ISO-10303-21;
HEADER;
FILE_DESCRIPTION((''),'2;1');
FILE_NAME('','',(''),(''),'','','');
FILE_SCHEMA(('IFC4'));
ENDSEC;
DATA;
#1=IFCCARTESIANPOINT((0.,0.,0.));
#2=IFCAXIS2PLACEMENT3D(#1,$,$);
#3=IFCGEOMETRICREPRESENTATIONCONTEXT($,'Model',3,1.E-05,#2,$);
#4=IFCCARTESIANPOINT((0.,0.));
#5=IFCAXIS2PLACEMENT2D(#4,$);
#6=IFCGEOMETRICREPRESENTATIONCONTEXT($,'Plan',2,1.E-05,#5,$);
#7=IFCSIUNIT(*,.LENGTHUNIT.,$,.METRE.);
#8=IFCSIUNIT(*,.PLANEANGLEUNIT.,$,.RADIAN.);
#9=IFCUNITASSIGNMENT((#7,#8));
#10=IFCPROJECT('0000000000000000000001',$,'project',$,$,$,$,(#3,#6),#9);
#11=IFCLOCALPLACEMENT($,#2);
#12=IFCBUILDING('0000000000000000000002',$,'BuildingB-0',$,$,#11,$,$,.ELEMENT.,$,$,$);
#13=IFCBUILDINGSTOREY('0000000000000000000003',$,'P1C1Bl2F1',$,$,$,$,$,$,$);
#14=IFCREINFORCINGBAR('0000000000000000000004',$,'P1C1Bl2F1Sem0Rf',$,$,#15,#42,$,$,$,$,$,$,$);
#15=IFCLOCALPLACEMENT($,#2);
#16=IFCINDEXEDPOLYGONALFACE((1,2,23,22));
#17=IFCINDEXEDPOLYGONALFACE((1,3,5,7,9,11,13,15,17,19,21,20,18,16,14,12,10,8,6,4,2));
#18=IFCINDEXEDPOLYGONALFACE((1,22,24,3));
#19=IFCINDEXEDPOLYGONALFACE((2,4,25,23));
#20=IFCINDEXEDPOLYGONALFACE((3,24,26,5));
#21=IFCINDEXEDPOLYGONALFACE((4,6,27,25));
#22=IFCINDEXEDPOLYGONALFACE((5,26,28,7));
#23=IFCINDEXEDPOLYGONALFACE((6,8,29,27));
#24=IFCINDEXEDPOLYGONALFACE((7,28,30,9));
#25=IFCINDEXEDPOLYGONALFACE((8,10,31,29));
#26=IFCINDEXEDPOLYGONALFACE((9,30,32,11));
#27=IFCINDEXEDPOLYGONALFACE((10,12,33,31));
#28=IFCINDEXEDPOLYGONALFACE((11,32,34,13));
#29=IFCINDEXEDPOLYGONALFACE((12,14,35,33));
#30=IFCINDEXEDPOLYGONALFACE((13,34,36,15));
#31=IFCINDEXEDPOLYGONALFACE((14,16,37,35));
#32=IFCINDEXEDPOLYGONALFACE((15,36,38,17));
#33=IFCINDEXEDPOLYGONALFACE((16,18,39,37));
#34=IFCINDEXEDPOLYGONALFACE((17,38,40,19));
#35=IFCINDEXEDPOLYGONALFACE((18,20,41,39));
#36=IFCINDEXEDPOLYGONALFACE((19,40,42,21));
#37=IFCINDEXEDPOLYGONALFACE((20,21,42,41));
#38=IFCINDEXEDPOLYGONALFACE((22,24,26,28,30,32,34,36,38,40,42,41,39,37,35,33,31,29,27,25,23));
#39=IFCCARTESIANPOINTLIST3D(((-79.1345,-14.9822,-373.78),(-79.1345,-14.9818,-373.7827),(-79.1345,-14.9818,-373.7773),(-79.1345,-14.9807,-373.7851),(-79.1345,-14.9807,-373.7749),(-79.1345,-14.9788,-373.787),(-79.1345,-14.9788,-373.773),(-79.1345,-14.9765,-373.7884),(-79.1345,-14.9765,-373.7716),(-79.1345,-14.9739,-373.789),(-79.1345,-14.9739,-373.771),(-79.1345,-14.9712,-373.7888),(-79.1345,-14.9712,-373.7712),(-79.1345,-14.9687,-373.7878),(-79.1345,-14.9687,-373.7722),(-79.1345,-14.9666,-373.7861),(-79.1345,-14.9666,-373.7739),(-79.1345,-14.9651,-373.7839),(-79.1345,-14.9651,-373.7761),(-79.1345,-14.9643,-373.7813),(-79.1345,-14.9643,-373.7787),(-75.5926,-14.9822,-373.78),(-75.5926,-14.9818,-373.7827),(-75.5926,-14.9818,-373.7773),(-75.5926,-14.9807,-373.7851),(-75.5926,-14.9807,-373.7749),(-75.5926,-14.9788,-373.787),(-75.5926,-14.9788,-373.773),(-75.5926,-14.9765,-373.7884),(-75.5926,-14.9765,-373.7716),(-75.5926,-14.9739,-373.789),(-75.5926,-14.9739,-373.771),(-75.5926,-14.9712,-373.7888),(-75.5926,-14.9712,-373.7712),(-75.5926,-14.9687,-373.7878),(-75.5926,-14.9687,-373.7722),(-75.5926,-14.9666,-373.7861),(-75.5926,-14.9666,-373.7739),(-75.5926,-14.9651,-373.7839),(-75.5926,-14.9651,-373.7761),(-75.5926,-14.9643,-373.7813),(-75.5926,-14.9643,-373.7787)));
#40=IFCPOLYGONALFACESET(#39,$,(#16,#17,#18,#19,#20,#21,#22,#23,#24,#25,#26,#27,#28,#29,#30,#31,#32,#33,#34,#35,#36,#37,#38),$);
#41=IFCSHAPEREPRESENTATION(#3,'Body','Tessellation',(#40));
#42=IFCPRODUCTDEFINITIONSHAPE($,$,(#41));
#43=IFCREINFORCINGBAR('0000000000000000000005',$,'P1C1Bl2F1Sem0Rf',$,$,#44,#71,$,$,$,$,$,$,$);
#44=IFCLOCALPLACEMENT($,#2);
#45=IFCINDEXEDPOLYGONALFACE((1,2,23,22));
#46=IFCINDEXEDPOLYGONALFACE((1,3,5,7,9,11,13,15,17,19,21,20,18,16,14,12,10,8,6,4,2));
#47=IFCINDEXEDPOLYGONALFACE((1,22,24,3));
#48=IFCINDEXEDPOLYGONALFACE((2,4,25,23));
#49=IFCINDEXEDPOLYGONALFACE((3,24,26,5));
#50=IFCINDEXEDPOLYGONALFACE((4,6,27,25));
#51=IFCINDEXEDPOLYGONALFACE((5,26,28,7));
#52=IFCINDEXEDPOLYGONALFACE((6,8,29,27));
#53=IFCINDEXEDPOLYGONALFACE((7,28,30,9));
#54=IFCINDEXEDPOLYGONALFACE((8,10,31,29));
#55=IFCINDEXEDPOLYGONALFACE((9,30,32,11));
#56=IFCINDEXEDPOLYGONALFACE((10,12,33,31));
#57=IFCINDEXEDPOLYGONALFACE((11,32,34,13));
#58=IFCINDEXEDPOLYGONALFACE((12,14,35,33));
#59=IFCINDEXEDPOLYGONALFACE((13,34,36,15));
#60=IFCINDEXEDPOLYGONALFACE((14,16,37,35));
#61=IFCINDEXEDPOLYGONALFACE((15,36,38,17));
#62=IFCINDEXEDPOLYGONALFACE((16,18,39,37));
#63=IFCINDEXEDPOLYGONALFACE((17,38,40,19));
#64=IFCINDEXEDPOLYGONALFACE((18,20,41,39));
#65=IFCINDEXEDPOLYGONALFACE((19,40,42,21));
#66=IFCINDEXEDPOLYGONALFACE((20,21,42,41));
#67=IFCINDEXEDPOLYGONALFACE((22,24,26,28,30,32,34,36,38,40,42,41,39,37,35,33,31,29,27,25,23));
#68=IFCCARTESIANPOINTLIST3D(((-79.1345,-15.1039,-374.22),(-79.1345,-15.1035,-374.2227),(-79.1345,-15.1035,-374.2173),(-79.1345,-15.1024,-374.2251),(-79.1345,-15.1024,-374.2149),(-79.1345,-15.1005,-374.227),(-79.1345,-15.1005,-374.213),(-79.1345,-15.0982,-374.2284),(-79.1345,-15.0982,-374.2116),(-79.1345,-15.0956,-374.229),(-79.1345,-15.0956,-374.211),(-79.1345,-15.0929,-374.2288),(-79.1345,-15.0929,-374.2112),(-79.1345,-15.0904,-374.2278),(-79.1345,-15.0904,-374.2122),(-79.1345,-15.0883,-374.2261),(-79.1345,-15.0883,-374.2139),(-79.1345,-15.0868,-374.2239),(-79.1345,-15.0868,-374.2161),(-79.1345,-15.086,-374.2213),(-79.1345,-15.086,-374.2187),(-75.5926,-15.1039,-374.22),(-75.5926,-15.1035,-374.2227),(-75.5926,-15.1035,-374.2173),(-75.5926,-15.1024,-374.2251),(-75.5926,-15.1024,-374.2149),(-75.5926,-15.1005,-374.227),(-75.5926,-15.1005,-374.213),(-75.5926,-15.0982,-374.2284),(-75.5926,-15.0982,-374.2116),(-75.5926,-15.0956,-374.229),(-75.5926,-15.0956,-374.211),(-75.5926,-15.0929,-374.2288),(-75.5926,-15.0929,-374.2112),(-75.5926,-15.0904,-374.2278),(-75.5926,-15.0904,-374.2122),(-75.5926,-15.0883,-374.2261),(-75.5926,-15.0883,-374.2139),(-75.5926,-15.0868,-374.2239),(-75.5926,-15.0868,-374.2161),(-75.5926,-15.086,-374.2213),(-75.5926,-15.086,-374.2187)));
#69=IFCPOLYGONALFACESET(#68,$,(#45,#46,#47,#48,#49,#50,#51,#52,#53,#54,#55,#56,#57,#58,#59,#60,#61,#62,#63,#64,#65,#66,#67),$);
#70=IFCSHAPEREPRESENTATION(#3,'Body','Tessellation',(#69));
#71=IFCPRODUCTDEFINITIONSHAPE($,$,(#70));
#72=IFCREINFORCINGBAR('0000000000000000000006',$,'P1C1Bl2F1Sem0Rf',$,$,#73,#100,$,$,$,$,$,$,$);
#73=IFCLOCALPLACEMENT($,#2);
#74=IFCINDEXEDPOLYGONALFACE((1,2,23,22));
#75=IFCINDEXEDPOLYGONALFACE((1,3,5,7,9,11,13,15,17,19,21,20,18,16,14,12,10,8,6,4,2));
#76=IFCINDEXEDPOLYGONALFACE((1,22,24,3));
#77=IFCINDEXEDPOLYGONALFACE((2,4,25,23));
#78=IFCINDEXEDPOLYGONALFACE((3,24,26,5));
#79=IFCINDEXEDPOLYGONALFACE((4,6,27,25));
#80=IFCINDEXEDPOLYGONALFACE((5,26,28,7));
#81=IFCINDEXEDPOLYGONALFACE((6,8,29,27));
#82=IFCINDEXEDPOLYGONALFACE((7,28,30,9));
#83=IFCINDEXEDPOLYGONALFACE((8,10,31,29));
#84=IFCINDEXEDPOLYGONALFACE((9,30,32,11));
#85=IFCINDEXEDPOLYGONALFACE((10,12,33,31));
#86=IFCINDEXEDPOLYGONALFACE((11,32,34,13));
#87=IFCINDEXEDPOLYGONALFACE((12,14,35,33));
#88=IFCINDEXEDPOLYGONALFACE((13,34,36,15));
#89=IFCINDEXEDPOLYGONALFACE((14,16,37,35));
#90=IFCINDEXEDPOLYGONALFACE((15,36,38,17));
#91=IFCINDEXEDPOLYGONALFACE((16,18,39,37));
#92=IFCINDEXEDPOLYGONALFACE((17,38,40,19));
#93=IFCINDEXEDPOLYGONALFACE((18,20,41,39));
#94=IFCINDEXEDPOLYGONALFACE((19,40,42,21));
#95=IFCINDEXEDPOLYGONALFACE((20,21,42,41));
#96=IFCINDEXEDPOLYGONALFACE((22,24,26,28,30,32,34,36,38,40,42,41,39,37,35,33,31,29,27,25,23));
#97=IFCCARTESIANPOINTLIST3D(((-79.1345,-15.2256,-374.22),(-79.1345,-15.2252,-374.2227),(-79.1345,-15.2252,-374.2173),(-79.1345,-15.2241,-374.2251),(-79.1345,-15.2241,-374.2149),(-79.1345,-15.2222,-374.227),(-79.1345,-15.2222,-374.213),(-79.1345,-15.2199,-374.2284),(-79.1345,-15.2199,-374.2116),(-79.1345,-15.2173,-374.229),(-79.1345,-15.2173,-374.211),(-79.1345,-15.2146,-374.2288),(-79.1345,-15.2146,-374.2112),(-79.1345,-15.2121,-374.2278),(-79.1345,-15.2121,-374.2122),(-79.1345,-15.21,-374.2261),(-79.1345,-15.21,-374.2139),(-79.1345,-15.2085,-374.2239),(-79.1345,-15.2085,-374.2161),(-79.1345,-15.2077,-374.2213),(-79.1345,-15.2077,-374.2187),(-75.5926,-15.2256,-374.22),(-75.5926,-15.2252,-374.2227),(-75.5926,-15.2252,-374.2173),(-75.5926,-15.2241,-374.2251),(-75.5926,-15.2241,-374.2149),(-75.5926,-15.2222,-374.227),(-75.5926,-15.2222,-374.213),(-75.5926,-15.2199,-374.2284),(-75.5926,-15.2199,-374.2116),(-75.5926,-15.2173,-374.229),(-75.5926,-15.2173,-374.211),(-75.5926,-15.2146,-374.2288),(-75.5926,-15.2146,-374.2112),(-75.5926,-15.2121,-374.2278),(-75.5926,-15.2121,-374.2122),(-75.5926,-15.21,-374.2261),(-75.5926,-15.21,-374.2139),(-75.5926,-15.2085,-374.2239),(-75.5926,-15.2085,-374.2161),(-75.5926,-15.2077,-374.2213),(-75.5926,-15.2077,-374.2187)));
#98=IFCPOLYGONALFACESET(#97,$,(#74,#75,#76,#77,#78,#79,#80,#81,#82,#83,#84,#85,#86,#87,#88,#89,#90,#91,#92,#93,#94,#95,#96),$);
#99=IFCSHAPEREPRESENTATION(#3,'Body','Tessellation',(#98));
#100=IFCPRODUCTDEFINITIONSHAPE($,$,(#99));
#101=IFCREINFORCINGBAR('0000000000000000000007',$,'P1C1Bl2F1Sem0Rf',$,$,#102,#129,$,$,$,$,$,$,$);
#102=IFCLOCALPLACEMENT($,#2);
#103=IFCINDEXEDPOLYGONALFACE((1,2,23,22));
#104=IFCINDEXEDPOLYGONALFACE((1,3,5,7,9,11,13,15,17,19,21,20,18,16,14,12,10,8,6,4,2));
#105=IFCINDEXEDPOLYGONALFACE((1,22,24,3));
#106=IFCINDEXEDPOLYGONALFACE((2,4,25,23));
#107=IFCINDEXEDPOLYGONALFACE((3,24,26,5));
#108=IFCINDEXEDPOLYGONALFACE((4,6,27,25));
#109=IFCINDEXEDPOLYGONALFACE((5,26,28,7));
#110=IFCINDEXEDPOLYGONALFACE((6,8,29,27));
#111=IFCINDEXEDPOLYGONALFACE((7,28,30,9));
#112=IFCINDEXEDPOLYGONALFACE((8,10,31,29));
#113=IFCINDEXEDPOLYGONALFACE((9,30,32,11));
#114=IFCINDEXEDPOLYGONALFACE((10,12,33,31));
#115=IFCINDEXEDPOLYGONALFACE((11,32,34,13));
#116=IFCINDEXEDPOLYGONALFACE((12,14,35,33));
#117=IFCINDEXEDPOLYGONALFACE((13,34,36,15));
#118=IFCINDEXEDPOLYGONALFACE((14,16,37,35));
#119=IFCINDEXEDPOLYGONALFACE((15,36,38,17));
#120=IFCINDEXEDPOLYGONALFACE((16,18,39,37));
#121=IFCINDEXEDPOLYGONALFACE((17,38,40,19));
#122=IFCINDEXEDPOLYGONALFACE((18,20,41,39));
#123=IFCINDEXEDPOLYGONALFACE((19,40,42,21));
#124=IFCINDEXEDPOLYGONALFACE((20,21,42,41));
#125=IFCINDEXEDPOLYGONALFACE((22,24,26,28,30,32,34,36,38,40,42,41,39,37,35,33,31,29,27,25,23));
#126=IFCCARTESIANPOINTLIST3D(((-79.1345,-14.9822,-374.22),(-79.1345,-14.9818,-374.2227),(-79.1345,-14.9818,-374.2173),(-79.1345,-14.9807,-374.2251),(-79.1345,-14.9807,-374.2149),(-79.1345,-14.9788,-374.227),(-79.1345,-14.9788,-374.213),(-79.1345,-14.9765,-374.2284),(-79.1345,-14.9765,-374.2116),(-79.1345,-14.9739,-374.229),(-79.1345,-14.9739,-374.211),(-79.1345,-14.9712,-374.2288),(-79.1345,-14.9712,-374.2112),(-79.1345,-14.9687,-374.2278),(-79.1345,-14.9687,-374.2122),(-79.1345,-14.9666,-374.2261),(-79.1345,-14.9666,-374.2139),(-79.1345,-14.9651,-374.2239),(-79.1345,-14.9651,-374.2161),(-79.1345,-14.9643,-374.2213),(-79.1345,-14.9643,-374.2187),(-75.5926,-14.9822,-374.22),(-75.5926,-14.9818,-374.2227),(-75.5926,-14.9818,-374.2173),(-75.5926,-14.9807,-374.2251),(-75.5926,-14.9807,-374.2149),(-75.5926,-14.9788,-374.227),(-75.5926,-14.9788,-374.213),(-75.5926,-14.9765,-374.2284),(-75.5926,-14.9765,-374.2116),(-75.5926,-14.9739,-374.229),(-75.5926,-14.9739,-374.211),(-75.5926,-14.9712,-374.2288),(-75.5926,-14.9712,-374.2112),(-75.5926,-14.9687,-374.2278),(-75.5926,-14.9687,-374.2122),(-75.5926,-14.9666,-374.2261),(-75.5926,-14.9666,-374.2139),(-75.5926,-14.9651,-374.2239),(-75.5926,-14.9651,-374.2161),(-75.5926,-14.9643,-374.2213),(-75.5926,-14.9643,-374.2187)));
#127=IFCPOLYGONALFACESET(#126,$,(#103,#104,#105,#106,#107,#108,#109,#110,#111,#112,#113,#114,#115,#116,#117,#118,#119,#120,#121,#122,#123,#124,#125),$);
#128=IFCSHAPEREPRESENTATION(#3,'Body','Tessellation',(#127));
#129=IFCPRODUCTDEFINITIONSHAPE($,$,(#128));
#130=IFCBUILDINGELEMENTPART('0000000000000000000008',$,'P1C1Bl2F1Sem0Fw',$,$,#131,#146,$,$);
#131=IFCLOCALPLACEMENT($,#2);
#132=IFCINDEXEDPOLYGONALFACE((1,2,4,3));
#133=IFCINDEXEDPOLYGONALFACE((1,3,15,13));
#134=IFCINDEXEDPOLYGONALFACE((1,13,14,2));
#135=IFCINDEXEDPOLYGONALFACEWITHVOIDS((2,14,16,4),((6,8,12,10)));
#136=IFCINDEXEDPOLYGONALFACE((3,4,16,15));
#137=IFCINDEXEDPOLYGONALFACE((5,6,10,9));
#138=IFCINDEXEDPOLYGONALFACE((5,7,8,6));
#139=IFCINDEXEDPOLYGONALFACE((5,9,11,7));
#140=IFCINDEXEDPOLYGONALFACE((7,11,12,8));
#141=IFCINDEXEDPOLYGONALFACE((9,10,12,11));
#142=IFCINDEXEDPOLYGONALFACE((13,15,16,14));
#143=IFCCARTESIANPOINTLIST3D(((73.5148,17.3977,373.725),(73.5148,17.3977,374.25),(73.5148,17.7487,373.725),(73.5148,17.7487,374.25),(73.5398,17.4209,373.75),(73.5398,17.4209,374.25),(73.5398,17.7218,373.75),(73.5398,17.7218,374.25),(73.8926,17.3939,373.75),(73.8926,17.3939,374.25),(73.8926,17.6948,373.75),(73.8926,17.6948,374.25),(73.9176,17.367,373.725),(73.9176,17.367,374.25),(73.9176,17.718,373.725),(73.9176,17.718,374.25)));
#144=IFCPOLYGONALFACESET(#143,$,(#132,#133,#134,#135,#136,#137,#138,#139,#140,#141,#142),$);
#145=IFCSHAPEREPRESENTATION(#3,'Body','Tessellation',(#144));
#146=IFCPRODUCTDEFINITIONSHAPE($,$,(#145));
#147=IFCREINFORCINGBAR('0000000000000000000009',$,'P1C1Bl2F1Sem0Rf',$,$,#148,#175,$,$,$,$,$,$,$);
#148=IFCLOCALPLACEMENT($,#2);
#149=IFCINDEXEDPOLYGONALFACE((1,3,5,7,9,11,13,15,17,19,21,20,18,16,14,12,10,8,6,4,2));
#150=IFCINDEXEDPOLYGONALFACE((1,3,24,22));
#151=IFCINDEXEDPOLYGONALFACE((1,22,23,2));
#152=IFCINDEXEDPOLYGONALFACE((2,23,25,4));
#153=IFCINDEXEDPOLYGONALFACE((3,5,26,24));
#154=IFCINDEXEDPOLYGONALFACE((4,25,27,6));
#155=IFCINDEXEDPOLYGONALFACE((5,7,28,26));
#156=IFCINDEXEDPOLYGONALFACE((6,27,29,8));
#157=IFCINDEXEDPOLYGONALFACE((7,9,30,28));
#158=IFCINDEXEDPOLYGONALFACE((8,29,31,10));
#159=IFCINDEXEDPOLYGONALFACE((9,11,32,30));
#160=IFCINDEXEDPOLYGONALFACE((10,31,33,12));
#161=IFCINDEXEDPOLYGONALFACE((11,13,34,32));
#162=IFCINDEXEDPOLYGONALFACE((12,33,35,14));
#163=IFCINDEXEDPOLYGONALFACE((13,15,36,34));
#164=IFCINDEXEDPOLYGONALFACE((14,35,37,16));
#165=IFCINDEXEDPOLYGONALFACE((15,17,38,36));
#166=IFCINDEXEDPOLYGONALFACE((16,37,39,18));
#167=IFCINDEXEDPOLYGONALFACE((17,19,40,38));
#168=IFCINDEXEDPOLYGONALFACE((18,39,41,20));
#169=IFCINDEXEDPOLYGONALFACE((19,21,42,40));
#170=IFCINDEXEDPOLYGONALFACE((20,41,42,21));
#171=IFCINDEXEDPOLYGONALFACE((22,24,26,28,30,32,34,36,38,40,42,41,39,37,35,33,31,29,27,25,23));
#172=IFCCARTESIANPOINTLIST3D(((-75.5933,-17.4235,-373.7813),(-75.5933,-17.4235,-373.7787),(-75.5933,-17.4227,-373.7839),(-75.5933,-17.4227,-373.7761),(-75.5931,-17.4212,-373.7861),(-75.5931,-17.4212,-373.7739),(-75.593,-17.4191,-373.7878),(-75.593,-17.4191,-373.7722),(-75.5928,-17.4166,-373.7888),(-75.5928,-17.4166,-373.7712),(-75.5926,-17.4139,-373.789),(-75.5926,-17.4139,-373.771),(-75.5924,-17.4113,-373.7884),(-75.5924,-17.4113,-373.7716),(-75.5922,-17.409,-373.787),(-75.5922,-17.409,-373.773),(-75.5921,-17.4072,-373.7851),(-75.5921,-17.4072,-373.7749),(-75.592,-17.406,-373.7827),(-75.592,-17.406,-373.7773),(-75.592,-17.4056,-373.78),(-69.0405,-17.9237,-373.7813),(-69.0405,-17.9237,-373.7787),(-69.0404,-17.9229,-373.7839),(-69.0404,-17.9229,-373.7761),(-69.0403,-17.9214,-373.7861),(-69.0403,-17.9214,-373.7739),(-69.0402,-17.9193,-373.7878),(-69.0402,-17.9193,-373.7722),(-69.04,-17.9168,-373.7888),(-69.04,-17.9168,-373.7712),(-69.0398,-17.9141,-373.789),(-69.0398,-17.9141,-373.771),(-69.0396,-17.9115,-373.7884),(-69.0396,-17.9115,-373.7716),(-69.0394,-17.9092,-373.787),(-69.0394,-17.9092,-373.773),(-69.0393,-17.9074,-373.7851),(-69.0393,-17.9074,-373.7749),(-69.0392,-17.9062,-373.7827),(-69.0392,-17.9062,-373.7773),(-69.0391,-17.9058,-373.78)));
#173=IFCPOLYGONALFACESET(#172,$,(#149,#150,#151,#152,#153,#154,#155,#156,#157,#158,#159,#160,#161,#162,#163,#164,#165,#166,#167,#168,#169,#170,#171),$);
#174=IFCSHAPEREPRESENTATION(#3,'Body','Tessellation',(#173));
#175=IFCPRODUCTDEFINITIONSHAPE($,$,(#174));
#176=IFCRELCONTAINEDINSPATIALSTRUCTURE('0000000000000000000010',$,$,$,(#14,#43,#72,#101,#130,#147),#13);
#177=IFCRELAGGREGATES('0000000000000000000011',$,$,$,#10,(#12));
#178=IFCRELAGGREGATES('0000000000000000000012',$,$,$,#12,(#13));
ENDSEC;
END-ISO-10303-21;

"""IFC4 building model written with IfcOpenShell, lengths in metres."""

from ifc_helpers import new_model, entity, si_unit, origin, origin_2d, place, context, project, spatial, polyline, outline, extrude, element, save


model = new_model("IFC4")

# Units and contexts
model_context = context("Model", 3, precision=1e-05, world=origin())
plan_context = context("Plan", 2, precision=1e-05, world=origin_2d())
ifc_project = project(units=[si_unit("LENGTHUNIT", "METRE"), si_unit("PLANEANGLEUNIT", "RADIAN")], contexts=[model_context, plan_context])

# Building, storey
building_placement = place(None, origin())
building = spatial("IfcBuilding", under=ifc_project, at=building_placement, Name="BuildingB-0", CompositionType="ELEMENT")
storey = spatial("IfcBuildingStorey", under=building, Name="P1C1Bl2F1")

# Reinforcing bars
element("IfcReinforcingBar", 1, inside=storey, Name="P1C1Bl2F1Sem0Rf", context=model_context, shape_type="SweptSolid", body=[
    entity("IfcSurfaceCurveSweptAreaSolid", entity("IfcCircleProfileDef", "AREA", None, None, 0.009), None, entity("IfcPolyline", [entity("IfcCartesianPoint", [79.1345, 14.9732, 373.78]), entity("IfcCartesianPoint", [75.5926, 14.9732, 373.78])]), None, None, entity("IfcPlane", entity("IfcAxis2Placement3D", entity("IfcCartesianPoint", [79.1345, 14.9732, 373.78]), entity("IfcDirection", [0.0, 0.0, 1.0]), entity("IfcDirection", [1.0, 0.0, 0.0])))),
])
element("IfcReinforcingBar", 2, inside=storey, Name="P1C1Bl2F1Sem0Rf", context=model_context, shape_type="SweptSolid", body=[
    entity("IfcSurfaceCurveSweptAreaSolid", entity("IfcCircleProfileDef", "AREA", None, None, 0.009), None, entity("IfcPolyline", [entity("IfcCartesianPoint", [79.1345, 15.0949, 374.22]), entity("IfcCartesianPoint", [75.5926, 15.0949, 374.22])]), None, None, entity("IfcPlane", entity("IfcAxis2Placement3D", entity("IfcCartesianPoint", [79.1345, 15.0949, 374.22]), entity("IfcDirection", [0.0, 0.0, 1.0]), entity("IfcDirection", [1.0, 0.0, 0.0])))),
])
element("IfcReinforcingBar", 3, inside=storey, Name="P1C1Bl2F1Sem0Rf", context=model_context, shape_type="SweptSolid", body=[
    entity("IfcSurfaceCurveSweptAreaSolid", entity("IfcCircleProfileDef", "AREA", None, None, 0.009), None, entity("IfcPolyline", [entity("IfcCartesianPoint", [79.1345, 15.2166, 374.22]), entity("IfcCartesianPoint", [75.5926, 15.2166, 374.22])]), None, None, entity("IfcPlane", entity("IfcAxis2Placement3D", entity("IfcCartesianPoint", [79.1345, 15.2166, 374.22]), entity("IfcDirection", [0.0, 0.0, 1.0]), entity("IfcDirection", [1.0, 0.0, 0.0])))),
])
element("IfcReinforcingBar", 4, inside=storey, Name="P1C1Bl2F1Sem0Rf", context=model_context, shape_type="SweptSolid", body=[
    entity("IfcSurfaceCurveSweptAreaSolid", entity("IfcCircleProfileDef", "AREA", None, None, 0.009), None, entity("IfcPolyline", [entity("IfcCartesianPoint", [79.1345, 14.9732, 374.22]), entity("IfcCartesianPoint", [75.5926, 14.9732, 374.22])]), None, None, entity("IfcPlane", entity("IfcAxis2Placement3D", entity("IfcCartesianPoint", [79.1345, 14.9732, 374.22]), entity("IfcDirection", [0.0, 0.0, 1.0]), entity("IfcDirection", [1.0, 0.0, 0.0])))),
])

# Building element part, opening
building_element_part_1 = element("IfcBuildingElementPart", 5, inside=storey, Name="P1C1Bl2F1Sem0Fw", context=model_context, shape_type="SweptSolid", body=[
    extrude(outline(polyline([(73.9176, 17.367, 373.725), (73.5148, 17.3977, 373.725), (73.5148, 17.7487, 373.725), (73.9176, 17.718, 373.725), (73.9176, 17.367, 373.725)])), None, (0.0, 0.0, 1.0), 0.525),
])
element("IfcOpeningElement", 6, inside=storey, cuts=building_element_part_1, context=model_context, shape_type="SweptSolid", body=[
    extrude(outline(polyline([(73.8926, 17.3939, 373.75), (73.5398, 17.4209, 373.75), (73.5398, 17.7218, 373.75), (73.8926, 17.6948, 373.75), (73.8926, 17.3939, 373.75)])), None, (0.0, 0.0, 1.0), 0.5),
])

# Reinforcing bar
element("IfcReinforcingBar", 7, inside=storey, Name="P1C1Bl2F1Sem0Rf", context=model_context, shape_type="SweptSolid", body=[
    entity("IfcSurfaceCurveSweptAreaSolid", entity("IfcCircleProfileDef", "AREA", None, None, 0.009), None, entity("IfcPolyline", [entity("IfcCartesianPoint", [69.0398, 17.9148, 373.78]), entity("IfcCartesianPoint", [75.5926, 17.4146, 373.78])]), None, None, entity("IfcPlane", entity("IfcAxis2Placement3D", entity("IfcCartesianPoint", [69.0398, 17.9148, 373.78]), entity("IfcDirection", [0.0, 0.0, 1.0]), entity("IfcDirection", [1.0, 0.0, 0.0])))),
])

save(model, "model.ifc")
